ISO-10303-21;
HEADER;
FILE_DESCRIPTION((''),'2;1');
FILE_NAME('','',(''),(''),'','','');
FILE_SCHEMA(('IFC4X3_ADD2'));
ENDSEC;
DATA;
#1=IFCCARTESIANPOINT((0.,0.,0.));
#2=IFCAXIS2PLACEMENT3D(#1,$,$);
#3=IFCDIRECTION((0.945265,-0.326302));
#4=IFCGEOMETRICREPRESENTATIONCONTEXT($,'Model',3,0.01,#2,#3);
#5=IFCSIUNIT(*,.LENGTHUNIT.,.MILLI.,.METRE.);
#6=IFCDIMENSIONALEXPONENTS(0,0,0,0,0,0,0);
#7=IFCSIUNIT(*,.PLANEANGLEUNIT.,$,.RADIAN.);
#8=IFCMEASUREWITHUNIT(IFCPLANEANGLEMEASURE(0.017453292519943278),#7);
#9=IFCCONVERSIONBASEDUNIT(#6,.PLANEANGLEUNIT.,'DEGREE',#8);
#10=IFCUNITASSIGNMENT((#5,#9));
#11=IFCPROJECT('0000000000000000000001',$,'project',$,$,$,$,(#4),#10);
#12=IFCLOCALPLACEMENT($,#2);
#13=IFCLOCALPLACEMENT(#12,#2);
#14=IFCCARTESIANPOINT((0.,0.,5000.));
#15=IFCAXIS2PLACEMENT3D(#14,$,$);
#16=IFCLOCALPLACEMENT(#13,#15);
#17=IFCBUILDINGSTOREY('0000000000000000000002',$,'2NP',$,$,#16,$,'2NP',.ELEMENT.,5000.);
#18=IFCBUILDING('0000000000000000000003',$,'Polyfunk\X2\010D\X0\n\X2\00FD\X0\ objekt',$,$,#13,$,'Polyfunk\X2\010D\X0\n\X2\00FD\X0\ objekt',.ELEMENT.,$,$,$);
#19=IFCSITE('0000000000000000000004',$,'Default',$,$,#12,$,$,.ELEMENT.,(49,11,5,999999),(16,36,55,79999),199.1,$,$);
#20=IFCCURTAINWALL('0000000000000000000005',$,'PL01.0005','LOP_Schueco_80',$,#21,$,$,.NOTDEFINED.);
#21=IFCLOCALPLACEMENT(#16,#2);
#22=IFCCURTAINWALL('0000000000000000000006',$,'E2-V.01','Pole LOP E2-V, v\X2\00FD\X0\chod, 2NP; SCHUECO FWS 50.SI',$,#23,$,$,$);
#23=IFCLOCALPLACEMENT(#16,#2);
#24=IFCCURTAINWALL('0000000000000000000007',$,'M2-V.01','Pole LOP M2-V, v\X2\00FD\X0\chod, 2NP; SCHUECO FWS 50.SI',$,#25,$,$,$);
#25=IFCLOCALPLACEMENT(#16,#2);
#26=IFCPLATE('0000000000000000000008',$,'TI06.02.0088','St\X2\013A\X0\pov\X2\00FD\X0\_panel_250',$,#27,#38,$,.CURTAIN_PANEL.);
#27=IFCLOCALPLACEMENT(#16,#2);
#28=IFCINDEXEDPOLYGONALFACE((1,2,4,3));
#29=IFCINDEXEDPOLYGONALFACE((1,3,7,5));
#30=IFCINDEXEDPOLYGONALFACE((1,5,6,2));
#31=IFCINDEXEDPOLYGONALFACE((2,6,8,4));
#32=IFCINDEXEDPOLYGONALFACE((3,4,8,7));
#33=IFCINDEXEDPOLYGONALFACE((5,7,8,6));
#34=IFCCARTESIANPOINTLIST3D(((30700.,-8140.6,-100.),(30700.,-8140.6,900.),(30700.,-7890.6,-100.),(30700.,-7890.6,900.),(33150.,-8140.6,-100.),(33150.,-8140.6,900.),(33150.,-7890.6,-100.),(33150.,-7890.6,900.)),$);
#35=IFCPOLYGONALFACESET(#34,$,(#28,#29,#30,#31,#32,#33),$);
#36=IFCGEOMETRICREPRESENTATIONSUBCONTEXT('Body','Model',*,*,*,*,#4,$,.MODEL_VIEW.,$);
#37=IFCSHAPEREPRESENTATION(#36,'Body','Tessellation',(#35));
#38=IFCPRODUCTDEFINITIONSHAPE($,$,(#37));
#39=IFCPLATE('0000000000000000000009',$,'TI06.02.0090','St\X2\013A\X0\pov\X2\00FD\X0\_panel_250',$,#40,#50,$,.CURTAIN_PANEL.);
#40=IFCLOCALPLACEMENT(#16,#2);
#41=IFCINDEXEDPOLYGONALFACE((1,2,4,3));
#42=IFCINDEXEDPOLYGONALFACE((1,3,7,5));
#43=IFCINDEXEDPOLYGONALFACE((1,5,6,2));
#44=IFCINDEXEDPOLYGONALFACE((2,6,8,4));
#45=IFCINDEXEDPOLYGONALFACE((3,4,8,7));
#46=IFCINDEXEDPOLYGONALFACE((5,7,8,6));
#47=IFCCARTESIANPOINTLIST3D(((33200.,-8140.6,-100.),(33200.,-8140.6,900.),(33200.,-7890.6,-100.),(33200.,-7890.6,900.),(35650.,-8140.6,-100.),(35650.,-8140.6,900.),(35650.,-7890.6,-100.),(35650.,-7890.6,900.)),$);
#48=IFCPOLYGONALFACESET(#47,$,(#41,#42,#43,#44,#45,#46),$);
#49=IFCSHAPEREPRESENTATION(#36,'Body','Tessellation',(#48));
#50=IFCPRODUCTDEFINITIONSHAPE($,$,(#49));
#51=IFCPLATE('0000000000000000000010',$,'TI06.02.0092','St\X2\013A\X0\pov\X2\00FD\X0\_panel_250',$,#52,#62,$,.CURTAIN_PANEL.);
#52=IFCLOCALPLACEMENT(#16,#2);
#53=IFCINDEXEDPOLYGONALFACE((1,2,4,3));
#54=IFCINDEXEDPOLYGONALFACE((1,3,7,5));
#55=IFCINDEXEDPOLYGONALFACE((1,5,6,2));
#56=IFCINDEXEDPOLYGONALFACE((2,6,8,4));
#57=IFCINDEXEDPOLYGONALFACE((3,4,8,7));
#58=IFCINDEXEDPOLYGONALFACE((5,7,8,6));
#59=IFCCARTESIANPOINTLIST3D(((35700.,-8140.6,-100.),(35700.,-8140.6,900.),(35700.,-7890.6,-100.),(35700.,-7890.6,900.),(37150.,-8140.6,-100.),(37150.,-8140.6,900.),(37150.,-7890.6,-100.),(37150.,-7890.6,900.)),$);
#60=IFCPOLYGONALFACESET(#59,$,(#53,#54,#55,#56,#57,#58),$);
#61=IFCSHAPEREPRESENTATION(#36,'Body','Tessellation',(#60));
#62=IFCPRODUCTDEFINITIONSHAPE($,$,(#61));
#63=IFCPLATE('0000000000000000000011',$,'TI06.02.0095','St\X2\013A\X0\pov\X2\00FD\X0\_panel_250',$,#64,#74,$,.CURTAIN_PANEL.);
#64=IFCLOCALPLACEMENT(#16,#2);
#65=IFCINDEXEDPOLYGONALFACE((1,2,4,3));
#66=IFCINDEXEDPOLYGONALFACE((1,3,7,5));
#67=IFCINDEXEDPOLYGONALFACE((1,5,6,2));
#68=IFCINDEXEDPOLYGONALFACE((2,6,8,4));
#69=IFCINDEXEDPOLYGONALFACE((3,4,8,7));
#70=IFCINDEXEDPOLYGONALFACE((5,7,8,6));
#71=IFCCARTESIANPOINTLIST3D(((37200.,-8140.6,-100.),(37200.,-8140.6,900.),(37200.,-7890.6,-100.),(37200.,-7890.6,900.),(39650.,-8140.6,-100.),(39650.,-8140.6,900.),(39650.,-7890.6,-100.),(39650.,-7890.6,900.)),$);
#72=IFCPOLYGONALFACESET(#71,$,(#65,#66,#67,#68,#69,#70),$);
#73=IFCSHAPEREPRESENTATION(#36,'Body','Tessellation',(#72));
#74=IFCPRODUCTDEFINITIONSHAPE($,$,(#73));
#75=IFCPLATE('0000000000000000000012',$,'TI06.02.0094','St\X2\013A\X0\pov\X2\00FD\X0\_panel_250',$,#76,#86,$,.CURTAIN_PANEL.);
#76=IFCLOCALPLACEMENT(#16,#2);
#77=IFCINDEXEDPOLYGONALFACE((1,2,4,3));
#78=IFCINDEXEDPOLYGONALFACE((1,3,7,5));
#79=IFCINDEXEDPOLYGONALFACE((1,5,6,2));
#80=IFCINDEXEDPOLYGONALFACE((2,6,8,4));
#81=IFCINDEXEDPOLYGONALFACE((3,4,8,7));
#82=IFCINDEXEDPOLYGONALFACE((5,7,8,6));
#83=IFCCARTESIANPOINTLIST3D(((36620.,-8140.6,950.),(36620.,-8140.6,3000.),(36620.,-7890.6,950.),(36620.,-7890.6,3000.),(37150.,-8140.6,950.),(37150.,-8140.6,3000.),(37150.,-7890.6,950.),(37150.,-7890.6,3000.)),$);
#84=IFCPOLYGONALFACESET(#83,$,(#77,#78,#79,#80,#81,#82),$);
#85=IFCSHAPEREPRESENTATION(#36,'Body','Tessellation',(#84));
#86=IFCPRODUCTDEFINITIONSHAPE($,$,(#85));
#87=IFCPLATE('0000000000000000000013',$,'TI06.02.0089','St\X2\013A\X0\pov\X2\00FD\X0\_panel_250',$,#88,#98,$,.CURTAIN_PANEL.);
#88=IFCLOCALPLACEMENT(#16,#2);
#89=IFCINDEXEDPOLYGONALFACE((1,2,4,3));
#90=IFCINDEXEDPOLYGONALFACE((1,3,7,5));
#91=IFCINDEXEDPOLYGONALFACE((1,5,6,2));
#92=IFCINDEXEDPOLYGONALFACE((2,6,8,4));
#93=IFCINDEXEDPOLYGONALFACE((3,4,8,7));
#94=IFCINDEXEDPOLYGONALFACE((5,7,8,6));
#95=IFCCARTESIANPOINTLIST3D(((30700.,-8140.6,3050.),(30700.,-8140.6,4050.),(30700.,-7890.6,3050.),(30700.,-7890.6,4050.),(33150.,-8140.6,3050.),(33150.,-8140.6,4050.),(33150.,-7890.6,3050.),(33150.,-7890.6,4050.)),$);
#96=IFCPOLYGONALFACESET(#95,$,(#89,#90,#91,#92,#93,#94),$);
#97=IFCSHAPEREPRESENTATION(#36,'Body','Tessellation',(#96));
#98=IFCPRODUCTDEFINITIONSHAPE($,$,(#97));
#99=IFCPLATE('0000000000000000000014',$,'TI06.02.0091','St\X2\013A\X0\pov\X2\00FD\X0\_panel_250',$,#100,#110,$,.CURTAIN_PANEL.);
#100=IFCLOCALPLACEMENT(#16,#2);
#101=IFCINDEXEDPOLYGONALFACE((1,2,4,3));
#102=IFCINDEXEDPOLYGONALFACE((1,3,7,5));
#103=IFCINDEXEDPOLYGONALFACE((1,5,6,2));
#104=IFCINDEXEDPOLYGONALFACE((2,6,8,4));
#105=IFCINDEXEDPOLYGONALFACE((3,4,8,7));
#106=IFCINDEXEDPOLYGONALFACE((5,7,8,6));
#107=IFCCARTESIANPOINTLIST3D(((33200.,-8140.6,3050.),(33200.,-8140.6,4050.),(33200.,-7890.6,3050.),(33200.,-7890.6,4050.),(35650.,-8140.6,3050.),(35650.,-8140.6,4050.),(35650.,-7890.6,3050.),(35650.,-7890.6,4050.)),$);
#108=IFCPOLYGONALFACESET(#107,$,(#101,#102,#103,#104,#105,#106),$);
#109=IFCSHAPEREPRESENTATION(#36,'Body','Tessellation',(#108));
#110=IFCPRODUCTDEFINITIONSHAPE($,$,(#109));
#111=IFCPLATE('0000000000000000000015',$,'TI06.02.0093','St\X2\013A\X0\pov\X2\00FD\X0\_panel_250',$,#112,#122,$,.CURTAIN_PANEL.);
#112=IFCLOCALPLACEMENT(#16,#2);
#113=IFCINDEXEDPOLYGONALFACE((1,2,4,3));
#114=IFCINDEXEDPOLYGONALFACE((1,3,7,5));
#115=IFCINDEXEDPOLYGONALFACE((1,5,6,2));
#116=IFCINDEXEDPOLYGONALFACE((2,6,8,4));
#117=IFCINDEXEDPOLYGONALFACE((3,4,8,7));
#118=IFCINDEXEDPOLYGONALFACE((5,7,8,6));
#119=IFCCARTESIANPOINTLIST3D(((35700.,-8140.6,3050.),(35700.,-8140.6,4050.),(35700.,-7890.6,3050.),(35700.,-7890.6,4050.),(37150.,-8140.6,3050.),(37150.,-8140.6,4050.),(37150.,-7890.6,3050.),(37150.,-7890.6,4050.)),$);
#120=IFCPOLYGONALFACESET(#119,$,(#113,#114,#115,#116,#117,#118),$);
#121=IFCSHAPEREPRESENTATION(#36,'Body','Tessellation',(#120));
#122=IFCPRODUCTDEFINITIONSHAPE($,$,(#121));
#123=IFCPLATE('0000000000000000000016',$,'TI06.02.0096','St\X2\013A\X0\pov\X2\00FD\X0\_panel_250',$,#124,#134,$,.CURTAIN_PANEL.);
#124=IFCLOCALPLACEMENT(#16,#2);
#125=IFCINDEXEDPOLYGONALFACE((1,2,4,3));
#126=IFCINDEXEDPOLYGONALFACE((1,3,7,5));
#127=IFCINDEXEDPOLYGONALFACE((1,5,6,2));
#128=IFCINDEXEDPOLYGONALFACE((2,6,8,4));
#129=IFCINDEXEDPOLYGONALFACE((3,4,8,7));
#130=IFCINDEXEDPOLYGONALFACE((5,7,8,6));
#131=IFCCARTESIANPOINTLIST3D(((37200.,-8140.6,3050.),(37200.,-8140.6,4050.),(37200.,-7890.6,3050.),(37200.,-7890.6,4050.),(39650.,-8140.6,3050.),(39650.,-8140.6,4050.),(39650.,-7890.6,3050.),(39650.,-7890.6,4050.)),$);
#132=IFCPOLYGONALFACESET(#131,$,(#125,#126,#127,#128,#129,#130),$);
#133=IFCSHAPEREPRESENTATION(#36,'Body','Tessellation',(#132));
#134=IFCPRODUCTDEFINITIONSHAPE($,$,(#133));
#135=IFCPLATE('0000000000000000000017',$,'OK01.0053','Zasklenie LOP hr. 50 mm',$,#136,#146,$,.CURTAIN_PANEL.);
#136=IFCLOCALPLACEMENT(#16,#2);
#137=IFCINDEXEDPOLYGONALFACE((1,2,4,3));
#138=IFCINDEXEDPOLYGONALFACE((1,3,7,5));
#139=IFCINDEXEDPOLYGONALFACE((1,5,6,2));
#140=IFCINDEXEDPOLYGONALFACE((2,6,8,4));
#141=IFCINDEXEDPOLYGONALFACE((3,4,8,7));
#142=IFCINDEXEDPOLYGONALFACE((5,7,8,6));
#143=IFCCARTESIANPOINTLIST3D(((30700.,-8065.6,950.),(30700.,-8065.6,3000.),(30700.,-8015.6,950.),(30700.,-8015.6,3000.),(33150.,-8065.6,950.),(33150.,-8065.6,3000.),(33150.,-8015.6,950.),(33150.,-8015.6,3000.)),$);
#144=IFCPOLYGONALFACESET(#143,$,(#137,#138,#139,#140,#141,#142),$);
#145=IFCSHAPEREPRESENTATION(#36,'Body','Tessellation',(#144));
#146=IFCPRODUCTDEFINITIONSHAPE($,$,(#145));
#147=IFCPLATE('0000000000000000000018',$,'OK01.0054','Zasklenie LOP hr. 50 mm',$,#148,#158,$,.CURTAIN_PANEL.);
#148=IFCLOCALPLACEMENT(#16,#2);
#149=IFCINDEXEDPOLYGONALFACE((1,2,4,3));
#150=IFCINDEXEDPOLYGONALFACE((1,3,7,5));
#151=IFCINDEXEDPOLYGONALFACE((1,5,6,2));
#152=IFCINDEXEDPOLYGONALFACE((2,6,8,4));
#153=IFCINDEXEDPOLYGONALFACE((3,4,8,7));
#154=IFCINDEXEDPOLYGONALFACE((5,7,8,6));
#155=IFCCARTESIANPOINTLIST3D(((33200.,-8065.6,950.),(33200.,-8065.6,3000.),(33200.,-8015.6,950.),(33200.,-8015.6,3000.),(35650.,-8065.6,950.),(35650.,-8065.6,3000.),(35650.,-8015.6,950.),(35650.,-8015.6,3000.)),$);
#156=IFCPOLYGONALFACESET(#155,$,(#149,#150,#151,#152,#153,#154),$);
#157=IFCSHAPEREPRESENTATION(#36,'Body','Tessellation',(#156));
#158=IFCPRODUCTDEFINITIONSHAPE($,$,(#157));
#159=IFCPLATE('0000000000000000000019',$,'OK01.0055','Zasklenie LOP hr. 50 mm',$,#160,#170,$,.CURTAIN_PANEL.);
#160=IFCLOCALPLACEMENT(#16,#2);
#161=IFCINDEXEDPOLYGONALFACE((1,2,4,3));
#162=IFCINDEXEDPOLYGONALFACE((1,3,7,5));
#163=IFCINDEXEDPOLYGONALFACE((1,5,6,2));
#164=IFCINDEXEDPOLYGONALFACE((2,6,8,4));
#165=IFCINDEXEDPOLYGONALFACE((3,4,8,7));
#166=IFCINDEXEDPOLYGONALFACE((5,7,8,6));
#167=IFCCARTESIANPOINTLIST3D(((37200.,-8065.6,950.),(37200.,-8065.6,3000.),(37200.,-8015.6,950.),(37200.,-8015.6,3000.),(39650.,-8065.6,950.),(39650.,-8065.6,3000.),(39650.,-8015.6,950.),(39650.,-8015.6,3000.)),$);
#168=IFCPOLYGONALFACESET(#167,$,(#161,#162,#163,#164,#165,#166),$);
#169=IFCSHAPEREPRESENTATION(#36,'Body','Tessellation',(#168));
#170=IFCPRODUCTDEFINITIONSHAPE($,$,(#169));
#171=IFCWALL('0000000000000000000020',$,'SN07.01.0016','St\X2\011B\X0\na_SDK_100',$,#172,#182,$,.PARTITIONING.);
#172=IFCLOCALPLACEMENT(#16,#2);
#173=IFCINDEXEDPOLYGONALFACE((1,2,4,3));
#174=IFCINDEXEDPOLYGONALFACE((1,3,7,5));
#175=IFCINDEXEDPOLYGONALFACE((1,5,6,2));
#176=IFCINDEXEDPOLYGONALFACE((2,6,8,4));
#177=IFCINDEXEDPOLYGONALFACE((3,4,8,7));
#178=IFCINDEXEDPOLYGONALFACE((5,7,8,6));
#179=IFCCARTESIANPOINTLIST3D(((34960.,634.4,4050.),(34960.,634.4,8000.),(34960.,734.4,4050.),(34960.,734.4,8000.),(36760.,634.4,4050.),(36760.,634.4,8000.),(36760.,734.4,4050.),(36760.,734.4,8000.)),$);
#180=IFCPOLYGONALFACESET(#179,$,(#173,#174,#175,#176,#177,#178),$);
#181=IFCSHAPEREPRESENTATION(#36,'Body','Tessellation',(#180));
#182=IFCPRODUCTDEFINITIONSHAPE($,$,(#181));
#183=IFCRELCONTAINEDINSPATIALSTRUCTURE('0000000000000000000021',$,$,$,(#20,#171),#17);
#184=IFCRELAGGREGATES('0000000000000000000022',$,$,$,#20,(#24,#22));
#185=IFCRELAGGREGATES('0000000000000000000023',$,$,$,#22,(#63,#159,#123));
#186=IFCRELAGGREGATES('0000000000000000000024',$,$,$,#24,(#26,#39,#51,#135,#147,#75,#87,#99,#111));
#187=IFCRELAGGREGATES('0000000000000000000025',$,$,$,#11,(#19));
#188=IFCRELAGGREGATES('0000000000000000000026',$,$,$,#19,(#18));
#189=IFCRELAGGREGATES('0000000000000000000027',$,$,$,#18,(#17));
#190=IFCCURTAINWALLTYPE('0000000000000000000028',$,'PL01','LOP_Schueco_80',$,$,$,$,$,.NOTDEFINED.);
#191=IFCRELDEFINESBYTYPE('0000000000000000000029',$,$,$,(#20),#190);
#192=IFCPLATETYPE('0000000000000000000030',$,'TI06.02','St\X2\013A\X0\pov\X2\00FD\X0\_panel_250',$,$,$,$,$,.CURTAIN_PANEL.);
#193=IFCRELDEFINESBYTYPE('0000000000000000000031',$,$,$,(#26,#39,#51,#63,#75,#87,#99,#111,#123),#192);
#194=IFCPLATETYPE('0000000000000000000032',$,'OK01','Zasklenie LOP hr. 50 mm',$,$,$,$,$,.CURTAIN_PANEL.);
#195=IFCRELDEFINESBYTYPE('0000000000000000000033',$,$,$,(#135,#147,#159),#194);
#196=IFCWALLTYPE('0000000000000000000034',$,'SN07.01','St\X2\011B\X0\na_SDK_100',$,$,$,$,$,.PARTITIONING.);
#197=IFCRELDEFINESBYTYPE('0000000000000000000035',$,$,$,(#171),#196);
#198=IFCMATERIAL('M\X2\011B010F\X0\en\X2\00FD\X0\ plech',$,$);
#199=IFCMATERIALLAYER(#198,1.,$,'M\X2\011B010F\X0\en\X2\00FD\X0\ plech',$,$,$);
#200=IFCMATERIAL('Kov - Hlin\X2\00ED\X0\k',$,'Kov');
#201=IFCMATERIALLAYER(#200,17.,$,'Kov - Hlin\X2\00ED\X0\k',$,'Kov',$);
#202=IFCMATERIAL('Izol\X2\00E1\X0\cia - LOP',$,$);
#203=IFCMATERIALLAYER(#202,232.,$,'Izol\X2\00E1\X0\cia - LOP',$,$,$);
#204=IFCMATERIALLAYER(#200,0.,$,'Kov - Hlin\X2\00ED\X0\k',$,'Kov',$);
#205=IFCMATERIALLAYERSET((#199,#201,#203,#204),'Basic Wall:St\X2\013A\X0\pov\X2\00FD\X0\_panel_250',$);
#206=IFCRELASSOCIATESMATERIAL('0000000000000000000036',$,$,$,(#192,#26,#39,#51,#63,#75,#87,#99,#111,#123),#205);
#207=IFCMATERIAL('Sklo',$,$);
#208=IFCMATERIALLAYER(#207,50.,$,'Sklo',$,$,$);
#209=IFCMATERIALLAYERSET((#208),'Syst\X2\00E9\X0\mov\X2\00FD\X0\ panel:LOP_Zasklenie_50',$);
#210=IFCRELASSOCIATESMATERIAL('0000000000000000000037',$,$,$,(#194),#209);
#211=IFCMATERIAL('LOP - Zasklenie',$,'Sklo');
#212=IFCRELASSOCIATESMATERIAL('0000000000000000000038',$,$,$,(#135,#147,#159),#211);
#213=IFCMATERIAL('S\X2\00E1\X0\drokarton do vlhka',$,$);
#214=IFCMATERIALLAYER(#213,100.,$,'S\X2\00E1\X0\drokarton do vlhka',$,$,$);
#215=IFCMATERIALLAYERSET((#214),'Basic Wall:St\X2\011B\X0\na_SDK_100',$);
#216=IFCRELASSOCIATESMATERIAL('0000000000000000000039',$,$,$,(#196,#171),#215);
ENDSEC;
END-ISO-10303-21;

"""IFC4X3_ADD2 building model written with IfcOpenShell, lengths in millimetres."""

from ifc_helpers import new_model, entity, si_unit, converted_unit, direction, frame, frame_2d, origin, origin_2d_with_axis, place, context, subcontext, project, spatial, polyline, rectangle, extrude, clip, bounded_halfspace, source, transform, mapped, material, layer, layer_set, layer_usage, type_object, type_shapes, element, aggregate, save


model = new_model("IFC4X3_ADD2")

# Units and contexts
model_context = context("Model", 3, precision=0.01, world=origin(), true_north=direction((0.945265, -0.326302)))
body_context = subcontext(model_context, "Body", "Model", "MODEL_VIEW")
ifc_project = project(units=[si_unit("LENGTHUNIT", "METRE", prefix="MILLI"), converted_unit("PLANEANGLEUNIT", "DEGREE", entity("IfcPlaneAngleMeasure", 0.017453292519943278), si_unit("PLANEANGLEUNIT", "RADIAN"), dimensions=[0, 0, 0, 0, 0, 0, 0])], contexts=[model_context])

# Site, building, storey
site_placement = place(None, origin())
site = spatial("IfcSite", under=ifc_project, at=site_placement, Name="Default", CompositionType="ELEMENT", RefLatitude=(49, 11, 5, 999999), RefLongitude=(16, 36, 55, 79999), RefElevation=199.1)
building_placement = place(site_placement, origin())
building = spatial("IfcBuilding", under=site, at=building_placement, Name="Polyfunkčný objekt", LongName="Polyfunkčný objekt", CompositionType="ELEMENT")
storey_placement = place(building_placement, frame((0.0, 0.0, 5000.0)))
storey = spatial("IfcBuildingStorey", under=building, at=storey_placement, Name="2NP", LongName="2NP", CompositionType="ELEMENT", Elevation=5000.0)

# Curtain walls, plates
curtain_wall_type = type_object("IfcCurtainWallType", Name="PL01", Description="LOP_Schueco_80", PredefinedType="NOTDEFINED")
curtain_wall_1_placement = place(storey_placement, frame((0.0, 0.0, -5000.0)))
curtain_wall_1 = element("IfcCurtainWall", 1, at=curtain_wall_1_placement, inside=storey, type_object=curtain_wall_type, Name="PL01.0005", Description="LOP_Schueco_80", PredefinedType="NOTDEFINED")
curtain_wall_2 = element("IfcCurtainWall", 2, Name="E2-V.01", Description="Pole LOP E2-V, východ, 2NP; SCHUECO FWS 50.SI")
curtain_wall_3 = element("IfcCurtainWall", 3, Name="M2-V.01", Description="Pole LOP M2-V, východ, 2NP; SCHUECO FWS 50.SI")
aggregate(curtain_wall_1, [curtain_wall_3, curtain_wall_2])
ifc_material_1 = material(Name="Měďený plech")
ifc_layer_1 = layer(ifc_material_1, 1.0, Name="Měďený plech")
ifc_material_2 = material(Name="Kov - Hliník", Category="Kov")
ifc_layer_2 = layer(ifc_material_2, 17.0, Name="Kov - Hliník", Category="Kov")
ifc_material_3 = material(Name="Izolácia - LOP")
ifc_layer_3 = layer(ifc_material_3, 232.0, Name="Izolácia - LOP")
ifc_layer_4 = layer(ifc_material_2, 0.0, Name="Kov - Hliník", Category="Kov")
ifc_layer_set_1 = layer_set([ifc_layer_1, ifc_layer_2, ifc_layer_3, ifc_layer_4], Name="Basic Wall:Stĺpový_panel_250")
ifc_layer_usage_1 = layer_usage(ifc_layer_set_1, "AXIS2", "POSITIVE", -125.0)
plate_type_1 = type_object("IfcPlateType", Name="TI06.02", Description="Stĺpový_panel_250", PredefinedType="CURTAIN_PANEL", material=ifc_layer_set_1)
plate_1_placement = place(storey_placement, frame((30700.0, -8015.6, -100.0)))
plate_1 = element("IfcPlate", 4, at=plate_1_placement, type_object=plate_type_1, material=ifc_layer_usage_1, Name="TI06.02.0088", Description="Stĺpový_panel_250", PredefinedType="CURTAIN_PANEL", context=body_context, shape_type="SweptSolid", body=[
    extrude(rectangle(XDim=250.0, YDim=2450.0, at=frame_2d((0.0, 0.0), x_axis=(1.0, 0.0))), frame((1225.0, 0.0, 0.0), z_axis=(0.0, 0.0, 1.0), x_axis=(0.0, 1.0, 0.0)), (0.0, 0.0, 1.0), 1000.0),
])
ifc_layer_usage_2 = layer_usage(ifc_layer_set_1, "AXIS2", "POSITIVE", -125.0)
plate_2_placement = place(storey_placement, frame((33200.0, -8015.6, -100.0)))
plate_2 = element("IfcPlate", 5, at=plate_2_placement, type_object=plate_type_1, material=ifc_layer_usage_2, Name="TI06.02.0090", Description="Stĺpový_panel_250", PredefinedType="CURTAIN_PANEL", context=body_context, shape_type="SweptSolid", body=[
    extrude(rectangle(XDim=250.0, YDim=2450.0, at=frame_2d((0.0, 0.0), x_axis=(1.0, 0.0))), frame((1225.0, 0.0, 0.0), z_axis=(0.0, 0.0, 1.0), x_axis=(0.0, 1.0, 0.0)), (0.0, 0.0, 1.0), 1000.0),
])
ifc_layer_usage_3 = layer_usage(ifc_layer_set_1, "AXIS2", "POSITIVE", -125.0)
plate_3_placement = place(storey_placement, frame((35700.0, -8015.6, -100.0)))
plate_3 = element("IfcPlate", 6, at=plate_3_placement, type_object=plate_type_1, material=ifc_layer_usage_3, Name="TI06.02.0092", Description="Stĺpový_panel_250", PredefinedType="CURTAIN_PANEL", context=body_context, shape_type="SweptSolid", body=[
    extrude(rectangle(XDim=250.0, YDim=1450.0, at=frame_2d((0.0, 0.0), x_axis=(1.0, 0.0))), frame((725.0, 0.0, 0.0), z_axis=(0.0, 0.0, 1.0), x_axis=(0.0, 1.0, 0.0)), (0.0, 0.0, 1.0), 1000.0),
])
ifc_layer_usage_4 = layer_usage(ifc_layer_set_1, "AXIS2", "POSITIVE", -125.0)
plate_4_placement = place(storey_placement, frame((37200.0, -8015.6, -100.0)))
plate_4 = element("IfcPlate", 7, at=plate_4_placement, type_object=plate_type_1, material=ifc_layer_usage_4, Name="TI06.02.0095", Description="Stĺpový_panel_250", PredefinedType="CURTAIN_PANEL", context=body_context, shape_type="SweptSolid", body=[
    extrude(rectangle(XDim=250.0, YDim=2450.0, at=frame_2d((0.0, 0.0), x_axis=(1.0, 0.0))), frame((1225.0, 0.0, 0.0), z_axis=(0.0, 0.0, 1.0), x_axis=(0.0, 1.0, 0.0)), (0.0, 0.0, 1.0), 1000.0),
])
ifc_layer_usage_5 = layer_usage(ifc_layer_set_1, "AXIS2", "POSITIVE", -125.0)
plate_5_placement = place(storey_placement, frame((36620.0, -8015.6, 950.0)))
plate_5 = element("IfcPlate", 8, at=plate_5_placement, type_object=plate_type_1, material=ifc_layer_usage_5, Name="TI06.02.0094", Description="Stĺpový_panel_250", PredefinedType="CURTAIN_PANEL", context=body_context, shape_type="SweptSolid", body=[
    extrude(rectangle(XDim=250.0, YDim=530.0, at=frame_2d((0.0, 0.0), x_axis=(1.0, 0.0))), frame((265.0, 0.0, 0.0), z_axis=(0.0, 0.0, 1.0), x_axis=(0.0, 1.0, 0.0)), (0.0, 0.0, 1.0), 2050.0),
])
ifc_layer_usage_6 = layer_usage(ifc_layer_set_1, "AXIS2", "POSITIVE", -125.0)
plate_6_placement = place(storey_placement, frame((30700.0, -8015.6, 3050.0)))
plate_6 = element("IfcPlate", 9, at=plate_6_placement, type_object=plate_type_1, material=ifc_layer_usage_6, Name="TI06.02.0089", Description="Stĺpový_panel_250", PredefinedType="CURTAIN_PANEL", context=body_context, shape_type="SweptSolid", body=[
    extrude(rectangle(XDim=250.0, YDim=2450.0, at=frame_2d((0.0, 0.0), x_axis=(1.0, 0.0))), frame((1225.0, 0.0, 0.0), z_axis=(0.0, 0.0, 1.0), x_axis=(0.0, 1.0, 0.0)), (0.0, 0.0, 1.0), 1000.0),
])
ifc_layer_usage_7 = layer_usage(ifc_layer_set_1, "AXIS2", "POSITIVE", -125.0)
plate_7_placement = place(storey_placement, frame((33200.0, -8015.6, 3050.0)))
plate_7 = element("IfcPlate", 10, at=plate_7_placement, type_object=plate_type_1, material=ifc_layer_usage_7, Name="TI06.02.0091", Description="Stĺpový_panel_250", PredefinedType="CURTAIN_PANEL", context=body_context, shape_type="SweptSolid", body=[
    extrude(rectangle(XDim=250.0, YDim=2450.0, at=frame_2d((0.0, 0.0), x_axis=(1.0, 0.0))), frame((1225.0, 0.0, 0.0), z_axis=(0.0, 0.0, 1.0), x_axis=(0.0, 1.0, 0.0)), (0.0, 0.0, 1.0), 1000.0),
])
ifc_layer_usage_8 = layer_usage(ifc_layer_set_1, "AXIS2", "POSITIVE", -125.0)
plate_8_placement = place(storey_placement, frame((35700.0, -8015.6, 3050.0)))
plate_8 = element("IfcPlate", 11, at=plate_8_placement, type_object=plate_type_1, material=ifc_layer_usage_8, Name="TI06.02.0093", Description="Stĺpový_panel_250", PredefinedType="CURTAIN_PANEL", context=body_context, shape_type="SweptSolid", body=[
    extrude(rectangle(XDim=250.0, YDim=1450.0, at=frame_2d((0.0, 0.0), x_axis=(1.0, 0.0))), frame((725.0, 0.0, 0.0), z_axis=(0.0, 0.0, 1.0), x_axis=(0.0, 1.0, 0.0)), (0.0, 0.0, 1.0), 1000.0),
])
ifc_layer_usage_9 = layer_usage(ifc_layer_set_1, "AXIS2", "POSITIVE", -125.0)
plate_9_placement = place(storey_placement, frame((37200.0, -8015.6, 3050.0)))
plate_9 = element("IfcPlate", 12, at=plate_9_placement, type_object=plate_type_1, material=ifc_layer_usage_9, Name="TI06.02.0096", Description="Stĺpový_panel_250", PredefinedType="CURTAIN_PANEL", context=body_context, shape_type="SweptSolid", body=[
    extrude(rectangle(XDim=250.0, YDim=2450.0, at=frame_2d((0.0, 0.0), x_axis=(1.0, 0.0))), frame((1225.0, 0.0, 0.0), z_axis=(0.0, 0.0, 1.0), x_axis=(0.0, 1.0, 0.0)), (0.0, 0.0, 1.0), 1000.0),
])
ifc_material_4 = material(Name="LOP - Zasklenie", Category="Sklo")
ifc_material_5 = material(Name="Sklo")
ifc_layer_5 = layer(ifc_material_5, 50.0, Name="Sklo")
ifc_layer_set_2 = layer_set([ifc_layer_5], Name="Systémový panel:LOP_Zasklenie_50")
plate_type_2 = type_object("IfcPlateType", Name="OK01", Description="Zasklenie LOP hr. 50 mm", PredefinedType="CURTAIN_PANEL", material=ifc_layer_set_2)
shared_shape_1 = source(origin(), body_context, "Body", "SweptSolid", [
    extrude(rectangle(XDim=50.0, YDim=2450.0, at=origin_2d_with_axis()), frame((0.0, -25.0, 0.0), z_axis=(0.0, 0.0, 1.0), x_axis=(0.0, 1.0, 0.0)), (0.0, 0.0, 1.0), 2050.0),
])
type_shapes(plate_type_2, [shared_shape_1])
plate_10_placement = place(curtain_wall_1_placement, frame((31925.0, -8015.6, 5950.0)))
plate_10 = element("IfcPlate", 13, at=plate_10_placement, type_object=plate_type_2, material=ifc_material_4, Name="OK01.0053", Description="Zasklenie LOP hr. 50 mm", PredefinedType="CURTAIN_PANEL", context=body_context, shape_type="MappedRepresentation", body=[
    mapped(shared_shape_1, transform((0.0, 0.0, 0.0), scale=1.0)),
])
plate_11_placement = place(curtain_wall_1_placement, frame((34425.0, -8015.6, 5950.0)))
plate_11 = element("IfcPlate", 14, at=plate_11_placement, type_object=plate_type_2, material=ifc_material_4, Name="OK01.0054", Description="Zasklenie LOP hr. 50 mm", PredefinedType="CURTAIN_PANEL", context=body_context, shape_type="MappedRepresentation", body=[
    mapped(shared_shape_1, transform((0.0, 0.0, 0.0), scale=1.0)),
])
plate_12_placement = place(curtain_wall_1_placement, frame((38425.0, -8015.6, 5950.0)))
plate_12 = element("IfcPlate", 15, at=plate_12_placement, type_object=plate_type_2, material=ifc_material_4, Name="OK01.0055", Description="Zasklenie LOP hr. 50 mm", PredefinedType="CURTAIN_PANEL", context=body_context, shape_type="MappedRepresentation", body=[
    mapped(shared_shape_1, transform((0.0, 0.0, 0.0), scale=1.0)),
])
aggregate(curtain_wall_2, [plate_4, plate_12, plate_9])

# Wall
ifc_material_6 = material(Name="Sádrokarton do vlhka")
ifc_layer_6 = layer(ifc_material_6, 100.0, Name="Sádrokarton do vlhka")
ifc_layer_set_3 = layer_set([ifc_layer_6], Name="Basic Wall:Stěna_SDK_100")
wall_type_1 = type_object("IfcWallType", Name="SN07.01", Description="Stěna_SDK_100", PredefinedType="PARTITIONING", material=ifc_layer_set_3)
wall_1_placement = place(storey_placement, frame((34960.0, 684.4, 4050.0)))
element("IfcWall", 16, at=wall_1_placement, inside=storey, type_object=wall_type_1, material=ifc_layer_set_3, Name="SN07.01.0016", Description="Stěna_SDK_100", PredefinedType="PARTITIONING", context=body_context, shape_type="Clipping", body=[
    clip(clip(extrude(rectangle(XDim=1800.0, YDim=100.0, at=frame_2d((900.0, 0.0), x_axis=(-1.0, 0.0))), origin(), (0.0, 0.0, 1.0), 3950.0), bounded_halfspace(frame((1800.0, -50.0, 0.0), z_axis=(0.0, 0.0, 1.0), x_axis=(-1.0, 0.0, 0.0)), True, frame((1800.0, -50.0, 0.0)), polyline([(0.0, 0.0), (0.0, 100.0), (-1800.0, 100.0), (-1800.0, 0.0), (0.0, 0.0)]))), bounded_halfspace(frame((0.0, -50.0, 3950.0), z_axis=(0.0, 0.0, -1.0), x_axis=(1.0, 0.0, 0.0)), True, frame((0.0, -50.0, 3950.0)), polyline([(0.0, 0.0), (1800.0, 0.0), (1800.0, 100.0), (0.0, 100.0), (0.0, 0.0)]))),
])

aggregate(curtain_wall_3, [plate_1, plate_2, plate_3, plate_10, plate_11, plate_5, plate_6, plate_7, plate_8])

save(model, "model.ifc")
